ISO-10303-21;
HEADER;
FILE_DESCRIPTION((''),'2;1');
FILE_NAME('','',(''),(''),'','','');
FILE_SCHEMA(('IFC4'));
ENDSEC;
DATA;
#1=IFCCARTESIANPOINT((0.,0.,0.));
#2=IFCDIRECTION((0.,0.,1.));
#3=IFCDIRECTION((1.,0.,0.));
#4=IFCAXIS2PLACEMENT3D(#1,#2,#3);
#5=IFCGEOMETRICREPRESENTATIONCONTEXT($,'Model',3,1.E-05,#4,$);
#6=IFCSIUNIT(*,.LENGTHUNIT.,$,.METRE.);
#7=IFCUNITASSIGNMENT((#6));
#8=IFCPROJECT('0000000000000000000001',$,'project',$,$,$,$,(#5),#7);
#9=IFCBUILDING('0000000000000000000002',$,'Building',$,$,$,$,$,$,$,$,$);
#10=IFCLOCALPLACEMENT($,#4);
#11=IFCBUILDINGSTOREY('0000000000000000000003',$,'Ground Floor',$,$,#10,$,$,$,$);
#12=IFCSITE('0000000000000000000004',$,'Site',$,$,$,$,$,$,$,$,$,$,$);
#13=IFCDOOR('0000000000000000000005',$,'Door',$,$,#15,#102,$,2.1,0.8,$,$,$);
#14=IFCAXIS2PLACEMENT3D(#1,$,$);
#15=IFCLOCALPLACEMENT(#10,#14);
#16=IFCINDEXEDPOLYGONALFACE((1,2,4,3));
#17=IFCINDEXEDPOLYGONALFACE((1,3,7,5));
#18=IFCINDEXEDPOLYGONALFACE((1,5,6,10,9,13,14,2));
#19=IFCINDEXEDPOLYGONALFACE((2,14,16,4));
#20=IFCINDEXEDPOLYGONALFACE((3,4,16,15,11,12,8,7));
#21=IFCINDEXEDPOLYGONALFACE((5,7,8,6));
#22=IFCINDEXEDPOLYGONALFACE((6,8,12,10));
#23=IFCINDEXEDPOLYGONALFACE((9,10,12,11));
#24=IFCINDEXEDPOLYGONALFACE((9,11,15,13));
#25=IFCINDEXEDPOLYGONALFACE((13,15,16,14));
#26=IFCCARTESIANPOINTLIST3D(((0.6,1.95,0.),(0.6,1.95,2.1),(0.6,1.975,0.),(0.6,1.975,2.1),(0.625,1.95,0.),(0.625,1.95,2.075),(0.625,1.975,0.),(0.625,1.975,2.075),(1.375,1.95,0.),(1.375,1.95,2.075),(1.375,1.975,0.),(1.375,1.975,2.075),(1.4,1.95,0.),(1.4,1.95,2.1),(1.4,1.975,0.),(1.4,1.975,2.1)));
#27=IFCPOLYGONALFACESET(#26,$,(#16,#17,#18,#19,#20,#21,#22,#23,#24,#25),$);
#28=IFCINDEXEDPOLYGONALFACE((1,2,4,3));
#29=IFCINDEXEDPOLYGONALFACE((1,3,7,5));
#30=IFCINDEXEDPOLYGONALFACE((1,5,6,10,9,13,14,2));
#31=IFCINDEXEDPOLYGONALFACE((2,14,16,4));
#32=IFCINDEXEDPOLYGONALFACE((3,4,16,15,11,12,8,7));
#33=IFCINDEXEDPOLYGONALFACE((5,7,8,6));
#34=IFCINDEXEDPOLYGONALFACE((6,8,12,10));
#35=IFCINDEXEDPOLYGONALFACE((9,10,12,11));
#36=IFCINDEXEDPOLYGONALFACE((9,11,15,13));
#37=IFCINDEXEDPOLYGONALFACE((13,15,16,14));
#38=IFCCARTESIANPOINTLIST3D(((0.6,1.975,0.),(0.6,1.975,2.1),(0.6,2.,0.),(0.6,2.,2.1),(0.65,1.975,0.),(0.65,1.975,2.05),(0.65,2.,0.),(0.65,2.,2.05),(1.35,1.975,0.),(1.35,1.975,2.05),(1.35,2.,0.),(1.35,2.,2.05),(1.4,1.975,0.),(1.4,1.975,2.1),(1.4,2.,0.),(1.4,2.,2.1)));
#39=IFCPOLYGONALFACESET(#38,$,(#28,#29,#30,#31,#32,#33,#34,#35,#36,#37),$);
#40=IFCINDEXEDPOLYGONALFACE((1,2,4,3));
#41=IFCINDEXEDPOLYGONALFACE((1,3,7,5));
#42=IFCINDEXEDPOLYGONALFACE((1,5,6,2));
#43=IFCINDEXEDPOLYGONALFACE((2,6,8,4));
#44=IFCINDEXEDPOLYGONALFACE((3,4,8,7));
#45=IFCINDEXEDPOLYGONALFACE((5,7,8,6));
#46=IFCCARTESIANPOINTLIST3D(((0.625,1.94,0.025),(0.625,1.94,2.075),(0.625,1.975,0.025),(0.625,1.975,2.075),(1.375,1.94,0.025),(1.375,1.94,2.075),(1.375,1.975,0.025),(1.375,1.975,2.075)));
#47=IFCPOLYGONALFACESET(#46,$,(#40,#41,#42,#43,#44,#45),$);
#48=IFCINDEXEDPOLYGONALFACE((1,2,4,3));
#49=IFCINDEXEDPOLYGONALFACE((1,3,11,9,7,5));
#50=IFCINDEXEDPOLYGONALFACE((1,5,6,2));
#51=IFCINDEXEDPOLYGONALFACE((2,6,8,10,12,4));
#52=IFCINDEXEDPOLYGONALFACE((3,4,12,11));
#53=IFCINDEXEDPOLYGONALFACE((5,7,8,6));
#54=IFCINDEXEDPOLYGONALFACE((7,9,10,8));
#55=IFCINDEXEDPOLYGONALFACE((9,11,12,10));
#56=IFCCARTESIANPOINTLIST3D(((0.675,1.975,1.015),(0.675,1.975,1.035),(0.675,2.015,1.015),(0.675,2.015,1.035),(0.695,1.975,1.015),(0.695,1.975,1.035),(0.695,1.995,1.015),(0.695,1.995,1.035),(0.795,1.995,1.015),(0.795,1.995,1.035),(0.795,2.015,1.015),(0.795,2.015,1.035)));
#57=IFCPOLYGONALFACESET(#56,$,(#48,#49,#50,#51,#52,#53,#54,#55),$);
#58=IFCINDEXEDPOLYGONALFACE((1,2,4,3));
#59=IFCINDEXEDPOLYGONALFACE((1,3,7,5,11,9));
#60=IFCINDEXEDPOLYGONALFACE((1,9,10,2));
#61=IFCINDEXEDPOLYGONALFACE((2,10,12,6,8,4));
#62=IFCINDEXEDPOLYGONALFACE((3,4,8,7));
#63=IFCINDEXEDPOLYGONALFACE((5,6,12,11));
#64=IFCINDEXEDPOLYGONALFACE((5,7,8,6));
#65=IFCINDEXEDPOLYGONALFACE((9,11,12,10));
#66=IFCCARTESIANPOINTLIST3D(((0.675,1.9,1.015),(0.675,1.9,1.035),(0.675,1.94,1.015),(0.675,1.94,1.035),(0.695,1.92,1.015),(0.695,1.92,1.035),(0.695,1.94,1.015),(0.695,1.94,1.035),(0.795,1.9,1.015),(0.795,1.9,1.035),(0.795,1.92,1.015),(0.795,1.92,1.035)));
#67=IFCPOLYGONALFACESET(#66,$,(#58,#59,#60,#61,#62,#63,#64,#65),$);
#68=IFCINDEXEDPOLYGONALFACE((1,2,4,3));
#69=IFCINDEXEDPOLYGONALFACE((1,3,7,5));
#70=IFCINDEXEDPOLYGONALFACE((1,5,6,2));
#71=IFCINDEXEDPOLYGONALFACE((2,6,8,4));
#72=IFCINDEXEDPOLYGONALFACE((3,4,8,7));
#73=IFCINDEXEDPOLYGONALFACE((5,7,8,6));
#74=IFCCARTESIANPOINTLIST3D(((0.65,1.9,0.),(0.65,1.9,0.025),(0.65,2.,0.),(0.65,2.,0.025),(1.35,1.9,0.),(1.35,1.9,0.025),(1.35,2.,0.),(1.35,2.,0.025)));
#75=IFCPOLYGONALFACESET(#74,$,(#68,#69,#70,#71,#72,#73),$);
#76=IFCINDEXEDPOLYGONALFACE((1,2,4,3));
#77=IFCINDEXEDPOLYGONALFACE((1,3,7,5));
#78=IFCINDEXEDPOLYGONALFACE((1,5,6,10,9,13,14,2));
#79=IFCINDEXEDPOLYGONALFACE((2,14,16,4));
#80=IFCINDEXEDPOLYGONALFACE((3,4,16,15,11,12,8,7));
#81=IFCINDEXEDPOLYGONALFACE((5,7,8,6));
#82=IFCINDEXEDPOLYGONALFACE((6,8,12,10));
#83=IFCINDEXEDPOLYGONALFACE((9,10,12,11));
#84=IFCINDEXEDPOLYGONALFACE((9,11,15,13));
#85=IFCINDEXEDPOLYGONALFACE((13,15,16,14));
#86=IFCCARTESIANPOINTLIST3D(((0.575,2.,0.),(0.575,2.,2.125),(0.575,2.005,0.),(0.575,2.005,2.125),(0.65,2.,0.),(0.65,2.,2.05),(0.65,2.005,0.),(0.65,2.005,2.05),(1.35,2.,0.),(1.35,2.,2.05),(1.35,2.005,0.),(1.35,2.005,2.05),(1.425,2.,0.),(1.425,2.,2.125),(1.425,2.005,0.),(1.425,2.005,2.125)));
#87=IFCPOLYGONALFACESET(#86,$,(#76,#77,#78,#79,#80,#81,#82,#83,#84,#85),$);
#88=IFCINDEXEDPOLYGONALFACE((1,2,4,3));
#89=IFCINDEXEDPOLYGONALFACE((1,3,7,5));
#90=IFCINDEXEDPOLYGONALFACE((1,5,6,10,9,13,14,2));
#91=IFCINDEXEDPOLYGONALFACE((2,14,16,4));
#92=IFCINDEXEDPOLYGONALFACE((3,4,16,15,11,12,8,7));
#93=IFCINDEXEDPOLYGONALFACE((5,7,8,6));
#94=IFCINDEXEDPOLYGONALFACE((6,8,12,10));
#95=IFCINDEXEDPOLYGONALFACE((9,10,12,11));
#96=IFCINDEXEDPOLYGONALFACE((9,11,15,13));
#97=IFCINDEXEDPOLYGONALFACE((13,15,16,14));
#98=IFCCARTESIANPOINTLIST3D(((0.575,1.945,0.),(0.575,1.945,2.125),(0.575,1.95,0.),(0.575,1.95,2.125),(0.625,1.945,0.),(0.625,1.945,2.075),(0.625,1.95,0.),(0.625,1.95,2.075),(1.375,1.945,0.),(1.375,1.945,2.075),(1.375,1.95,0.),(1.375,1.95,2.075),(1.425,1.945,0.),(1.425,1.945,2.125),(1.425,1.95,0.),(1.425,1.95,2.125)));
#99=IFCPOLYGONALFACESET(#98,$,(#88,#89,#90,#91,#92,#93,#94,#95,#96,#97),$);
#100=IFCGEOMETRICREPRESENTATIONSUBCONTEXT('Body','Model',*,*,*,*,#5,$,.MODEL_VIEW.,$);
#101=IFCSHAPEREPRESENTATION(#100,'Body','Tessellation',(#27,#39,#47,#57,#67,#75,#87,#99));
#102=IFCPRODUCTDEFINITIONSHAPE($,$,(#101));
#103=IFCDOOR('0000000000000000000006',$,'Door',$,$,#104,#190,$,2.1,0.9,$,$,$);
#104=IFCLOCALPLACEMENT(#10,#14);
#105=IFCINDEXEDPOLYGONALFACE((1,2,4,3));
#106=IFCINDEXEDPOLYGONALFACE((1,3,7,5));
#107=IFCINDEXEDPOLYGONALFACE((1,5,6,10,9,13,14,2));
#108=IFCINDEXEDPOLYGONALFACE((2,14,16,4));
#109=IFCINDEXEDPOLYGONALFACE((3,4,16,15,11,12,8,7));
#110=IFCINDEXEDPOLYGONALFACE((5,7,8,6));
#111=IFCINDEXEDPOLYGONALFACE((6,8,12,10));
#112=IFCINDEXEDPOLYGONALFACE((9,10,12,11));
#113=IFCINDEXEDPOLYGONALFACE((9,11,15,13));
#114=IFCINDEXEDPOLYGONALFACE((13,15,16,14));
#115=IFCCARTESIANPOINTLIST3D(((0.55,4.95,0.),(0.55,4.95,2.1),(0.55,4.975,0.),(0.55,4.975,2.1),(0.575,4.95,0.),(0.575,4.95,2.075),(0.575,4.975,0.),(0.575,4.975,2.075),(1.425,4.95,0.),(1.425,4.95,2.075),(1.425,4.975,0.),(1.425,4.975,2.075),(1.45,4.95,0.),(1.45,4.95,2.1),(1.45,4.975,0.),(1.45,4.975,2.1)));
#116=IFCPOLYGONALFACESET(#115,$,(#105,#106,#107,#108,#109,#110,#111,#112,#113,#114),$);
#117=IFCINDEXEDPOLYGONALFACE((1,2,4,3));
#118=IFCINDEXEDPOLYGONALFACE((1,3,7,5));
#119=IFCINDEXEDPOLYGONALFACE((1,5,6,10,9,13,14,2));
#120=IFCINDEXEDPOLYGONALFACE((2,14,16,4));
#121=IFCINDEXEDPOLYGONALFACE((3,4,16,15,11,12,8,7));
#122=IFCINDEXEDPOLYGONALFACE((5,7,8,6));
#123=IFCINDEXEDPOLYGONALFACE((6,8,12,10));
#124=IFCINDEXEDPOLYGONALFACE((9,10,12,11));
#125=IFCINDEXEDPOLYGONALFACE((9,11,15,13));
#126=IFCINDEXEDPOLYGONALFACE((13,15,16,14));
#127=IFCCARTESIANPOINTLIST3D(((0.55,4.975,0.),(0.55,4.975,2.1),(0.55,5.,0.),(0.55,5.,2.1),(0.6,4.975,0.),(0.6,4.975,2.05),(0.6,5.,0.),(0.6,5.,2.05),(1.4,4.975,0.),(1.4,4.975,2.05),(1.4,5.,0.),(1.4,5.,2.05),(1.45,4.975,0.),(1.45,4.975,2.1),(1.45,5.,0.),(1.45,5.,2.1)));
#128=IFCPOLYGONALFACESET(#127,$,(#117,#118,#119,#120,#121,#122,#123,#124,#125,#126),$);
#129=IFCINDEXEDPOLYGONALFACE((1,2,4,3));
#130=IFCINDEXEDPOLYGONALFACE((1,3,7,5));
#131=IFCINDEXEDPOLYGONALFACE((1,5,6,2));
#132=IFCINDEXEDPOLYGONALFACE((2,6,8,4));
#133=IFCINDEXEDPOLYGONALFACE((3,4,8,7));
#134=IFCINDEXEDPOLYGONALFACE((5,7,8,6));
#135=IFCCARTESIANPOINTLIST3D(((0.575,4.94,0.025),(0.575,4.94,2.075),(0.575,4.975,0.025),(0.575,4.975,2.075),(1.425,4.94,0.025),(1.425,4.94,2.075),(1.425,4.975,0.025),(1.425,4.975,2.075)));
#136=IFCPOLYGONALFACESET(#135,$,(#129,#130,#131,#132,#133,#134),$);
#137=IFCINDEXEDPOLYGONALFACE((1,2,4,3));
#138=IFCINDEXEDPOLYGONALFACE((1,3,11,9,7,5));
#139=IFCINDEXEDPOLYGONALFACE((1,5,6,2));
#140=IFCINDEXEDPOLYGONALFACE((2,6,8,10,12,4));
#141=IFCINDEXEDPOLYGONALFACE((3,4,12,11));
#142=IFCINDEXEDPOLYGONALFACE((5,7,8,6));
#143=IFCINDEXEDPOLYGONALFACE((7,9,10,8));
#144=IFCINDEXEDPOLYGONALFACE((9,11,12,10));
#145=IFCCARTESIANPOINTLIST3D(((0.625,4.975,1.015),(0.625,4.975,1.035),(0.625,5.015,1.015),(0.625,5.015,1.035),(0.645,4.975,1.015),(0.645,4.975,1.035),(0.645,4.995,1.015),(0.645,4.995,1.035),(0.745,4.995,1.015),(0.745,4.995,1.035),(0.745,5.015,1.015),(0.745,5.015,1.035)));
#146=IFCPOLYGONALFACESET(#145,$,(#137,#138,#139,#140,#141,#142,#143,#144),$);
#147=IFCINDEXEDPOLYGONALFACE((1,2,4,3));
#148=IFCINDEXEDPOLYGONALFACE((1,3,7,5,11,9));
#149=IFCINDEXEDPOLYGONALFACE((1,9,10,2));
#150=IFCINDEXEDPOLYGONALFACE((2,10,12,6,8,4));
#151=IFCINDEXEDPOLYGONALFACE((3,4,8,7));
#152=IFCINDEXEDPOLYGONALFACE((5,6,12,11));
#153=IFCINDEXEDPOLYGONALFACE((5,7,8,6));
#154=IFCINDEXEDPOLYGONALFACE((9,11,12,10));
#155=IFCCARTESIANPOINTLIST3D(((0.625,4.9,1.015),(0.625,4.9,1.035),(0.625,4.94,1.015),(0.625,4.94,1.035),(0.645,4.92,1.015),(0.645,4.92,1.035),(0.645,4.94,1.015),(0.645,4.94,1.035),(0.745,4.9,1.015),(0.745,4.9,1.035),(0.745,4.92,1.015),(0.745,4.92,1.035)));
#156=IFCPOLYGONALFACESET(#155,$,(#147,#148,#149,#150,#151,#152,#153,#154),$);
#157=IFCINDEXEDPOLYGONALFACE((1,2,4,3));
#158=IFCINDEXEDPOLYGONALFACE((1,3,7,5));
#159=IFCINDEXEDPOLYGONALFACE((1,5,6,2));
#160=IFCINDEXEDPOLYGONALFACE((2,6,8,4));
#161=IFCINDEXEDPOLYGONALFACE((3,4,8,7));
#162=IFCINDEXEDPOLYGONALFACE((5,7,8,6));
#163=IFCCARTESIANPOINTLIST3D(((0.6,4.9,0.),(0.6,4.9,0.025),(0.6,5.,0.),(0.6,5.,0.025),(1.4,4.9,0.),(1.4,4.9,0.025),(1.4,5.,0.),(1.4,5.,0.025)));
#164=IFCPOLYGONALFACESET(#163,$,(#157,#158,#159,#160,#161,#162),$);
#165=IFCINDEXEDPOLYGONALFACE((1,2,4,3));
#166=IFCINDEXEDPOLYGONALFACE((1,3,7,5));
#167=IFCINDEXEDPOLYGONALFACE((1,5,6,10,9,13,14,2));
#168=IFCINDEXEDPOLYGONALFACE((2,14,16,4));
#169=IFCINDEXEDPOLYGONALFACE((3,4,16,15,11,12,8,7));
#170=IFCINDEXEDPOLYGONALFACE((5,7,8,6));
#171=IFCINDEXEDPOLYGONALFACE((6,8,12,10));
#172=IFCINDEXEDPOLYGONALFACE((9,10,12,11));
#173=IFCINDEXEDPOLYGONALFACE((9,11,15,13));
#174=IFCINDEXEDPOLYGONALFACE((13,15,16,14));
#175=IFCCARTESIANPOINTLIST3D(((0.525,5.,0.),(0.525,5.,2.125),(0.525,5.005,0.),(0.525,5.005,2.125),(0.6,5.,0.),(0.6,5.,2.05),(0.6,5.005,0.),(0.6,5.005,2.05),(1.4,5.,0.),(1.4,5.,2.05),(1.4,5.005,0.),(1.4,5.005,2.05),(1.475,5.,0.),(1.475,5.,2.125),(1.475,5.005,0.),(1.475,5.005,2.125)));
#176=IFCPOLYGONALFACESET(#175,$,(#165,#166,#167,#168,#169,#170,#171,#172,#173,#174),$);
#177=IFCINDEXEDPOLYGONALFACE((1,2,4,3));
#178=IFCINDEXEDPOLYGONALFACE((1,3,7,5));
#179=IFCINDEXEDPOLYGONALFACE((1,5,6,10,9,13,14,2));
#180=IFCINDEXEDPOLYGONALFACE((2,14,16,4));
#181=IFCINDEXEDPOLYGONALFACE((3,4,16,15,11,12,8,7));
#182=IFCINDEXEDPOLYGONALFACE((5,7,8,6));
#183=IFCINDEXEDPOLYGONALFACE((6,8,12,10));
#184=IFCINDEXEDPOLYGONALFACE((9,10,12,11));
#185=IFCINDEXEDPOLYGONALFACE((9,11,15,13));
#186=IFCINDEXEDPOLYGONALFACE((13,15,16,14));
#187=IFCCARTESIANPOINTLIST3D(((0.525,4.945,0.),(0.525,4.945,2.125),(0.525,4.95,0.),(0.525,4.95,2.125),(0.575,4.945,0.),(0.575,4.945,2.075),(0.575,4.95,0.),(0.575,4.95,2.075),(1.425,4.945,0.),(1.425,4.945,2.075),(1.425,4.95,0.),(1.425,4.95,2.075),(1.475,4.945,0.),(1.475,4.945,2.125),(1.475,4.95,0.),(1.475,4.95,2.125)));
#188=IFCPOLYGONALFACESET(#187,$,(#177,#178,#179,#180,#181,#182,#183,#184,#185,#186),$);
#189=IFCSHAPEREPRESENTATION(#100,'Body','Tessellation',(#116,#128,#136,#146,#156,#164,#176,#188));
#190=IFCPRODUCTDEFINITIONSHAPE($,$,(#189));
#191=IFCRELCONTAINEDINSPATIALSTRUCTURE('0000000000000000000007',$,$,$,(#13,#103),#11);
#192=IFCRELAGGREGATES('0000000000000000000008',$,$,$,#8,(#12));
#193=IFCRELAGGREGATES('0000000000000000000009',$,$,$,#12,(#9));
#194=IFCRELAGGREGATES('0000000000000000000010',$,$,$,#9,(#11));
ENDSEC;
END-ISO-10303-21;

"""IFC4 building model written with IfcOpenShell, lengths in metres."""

from ifc_helpers import new_model, si_unit, frame, origin_with_axes, place, context, subcontext, project, spatial, line, indexed_curve, outline, extrude, element, save


model = new_model("IFC4")

# Units and contexts
model_context = context("Model", 3, precision=1e-05, world=origin_with_axes())
body_context = subcontext(model_context, "Body", "Model", "MODEL_VIEW")
ifc_project = project(units=[si_unit("LENGTHUNIT", "METRE")], contexts=[model_context])

# Site, building, storey
site = spatial("IfcSite", under=ifc_project, Name="Site")
building = spatial("IfcBuilding", under=site, Name="Building")
storey_placement = place(None, origin_with_axes())
storey = spatial("IfcBuildingStorey", under=building, at=storey_placement, Name="Ground Floor")

# Doors
door_1_placement = place(storey_placement, frame((1.4, 2.0, 0.0), z_axis=(0.0, 0.0, 1.0), x_axis=(-1.0, 0.0, 0.0)))
element("IfcDoor", 1, at=door_1_placement, inside=storey, Name="Door", OverallHeight=2.1, OverallWidth=0.8, context=body_context, shape_type="SweptSolid", body=[
    extrude(outline(indexed_curve([(0.0, 0.0), (0.0, 2.1), (0.8, 2.1), (0.8, 0.0), (0.775, 0.0), (0.775, 2.075), (0.025, 2.075), (0.025, 0.0)], segments=[line(1, 2, 3, 4, 5, 6, 7, 8, 1)])), frame((0.0, 0.025, 0.0), z_axis=(0.0, -1.0, 0.0), x_axis=(1.0, 0.0, 0.0)), (0.0, 0.0, -1.0), 0.025),
    extrude(outline(indexed_curve([(0.0, 0.0), (0.0, 2.1), (0.8, 2.1), (0.8, 0.0), (0.75, 0.0), (0.75, 2.05), (0.05, 2.05), (0.05, 0.0)], segments=[line(1, 2, 3, 4, 5, 6, 7, 8, 1)])), frame((0.0, 0.0, 0.0), z_axis=(0.0, -1.0, 0.0), x_axis=(1.0, 0.0, 0.0)), (0.0, 0.0, -1.0), 0.025),
    extrude(outline(indexed_curve([(0.0, 0.0), (0.75, 0.0), (0.75, 0.035), (0.0, 0.035)], segments=[line(1, 2, 3, 4, 1)])), frame((0.025, 0.025, 0.025), z_axis=(0.0, 0.0, 1.0), x_axis=(1.0, 0.0, 0.0)), (0.0, 0.0, 1.0), 2.05),
    extrude(outline(indexed_curve([(0.0, 0.0), (0.0, -0.04), (-0.12, -0.04), (-0.12, -0.02), (-0.02, -0.02), (-0.02, 0.0)], segments=[line(1, 2, 3, 4, 5, 6, 1)])), frame((0.725, 0.025, 1.015), z_axis=(0.0, 0.0, 1.0), x_axis=(1.0, 0.0, 0.0)), (0.0, 0.0, 1.0), 0.02),
    extrude(outline(indexed_curve([(0.0, 0.0), (0.0, 0.04), (-0.12, 0.04), (-0.12, 0.02), (-0.02, 0.02), (-0.02, 0.0)], segments=[line(1, 2, 3, 4, 5, 6, 1)])), frame((0.725, 0.06, 1.015), z_axis=(0.0, 0.0, 1.0), x_axis=(1.0, 0.0, 0.0)), (0.0, 0.0, 1.0), 0.02),
    extrude(outline(indexed_curve([(0.0, 0.0), (0.7, 0.0), (0.7, 0.1), (0.0, 0.1)], segments=[line(1, 2, 3, 4, 1)])), frame((0.05, 0.0, 0.0), z_axis=(0.0, 0.0, 1.0), x_axis=(1.0, 0.0, 0.0)), (0.0, 0.0, 1.0), 0.025),
    extrude(outline(indexed_curve([(0.0, 0.0), (0.0, 2.125), (0.85, 2.125), (0.85, 0.0), (0.775, 0.0), (0.775, 2.05), (0.075, 2.05), (0.075, 0.0)], segments=[line(1, 2, 3, 4, 5, 6, 7, 8, 1)])), frame((-0.025, -0.005, 0.0), z_axis=(0.0, -1.0, 0.0), x_axis=(1.0, 0.0, 0.0)), (0.0, 0.0, -1.0), 0.005),
    extrude(outline(indexed_curve([(0.0, 0.0), (0.0, 2.125), (0.85, 2.125), (0.85, 0.0), (0.8, 0.0), (0.8, 2.075), (0.05, 2.075), (0.05, 0.0)], segments=[line(1, 2, 3, 4, 5, 6, 7, 8, 1)])), frame((-0.025, 0.05, 0.0), z_axis=(0.0, -1.0, 0.0), x_axis=(1.0, 0.0, 0.0)), (0.0, 0.0, -1.0), 0.005),
])
door_2_placement = place(storey_placement, frame((1.45, 5.0, 0.0), z_axis=(0.0, 0.0, 1.0), x_axis=(-1.0, 0.0, 0.0)))
element("IfcDoor", 2, at=door_2_placement, inside=storey, Name="Door", OverallHeight=2.1, OverallWidth=0.9, context=body_context, shape_type="SweptSolid", body=[
    extrude(outline(indexed_curve([(0.0, 0.0), (0.0, 2.1), (0.9, 2.1), (0.9, 0.0), (0.875, 0.0), (0.875, 2.075), (0.025, 2.075), (0.025, 0.0)], segments=[line(1, 2, 3, 4, 5, 6, 7, 8, 1)])), frame((0.0, 0.025, 0.0), z_axis=(0.0, -1.0, 0.0), x_axis=(1.0, 0.0, 0.0)), (0.0, 0.0, -1.0), 0.025),
    extrude(outline(indexed_curve([(0.0, 0.0), (0.0, 2.1), (0.9, 2.1), (0.9, 0.0), (0.85, 0.0), (0.85, 2.05), (0.05, 2.05), (0.05, 0.0)], segments=[line(1, 2, 3, 4, 5, 6, 7, 8, 1)])), frame((0.0, 0.0, 0.0), z_axis=(0.0, -1.0, 0.0), x_axis=(1.0, 0.0, 0.0)), (0.0, 0.0, -1.0), 0.025),
    extrude(outline(indexed_curve([(0.0, 0.0), (0.85, 0.0), (0.85, 0.035), (0.0, 0.035)], segments=[line(1, 2, 3, 4, 1)])), frame((0.025, 0.025, 0.025), z_axis=(0.0, 0.0, 1.0), x_axis=(1.0, 0.0, 0.0)), (0.0, 0.0, 1.0), 2.05),
    extrude(outline(indexed_curve([(0.0, 0.0), (0.0, -0.04), (-0.12, -0.04), (-0.12, -0.02), (-0.02, -0.02), (-0.02, 0.0)], segments=[line(1, 2, 3, 4, 5, 6, 1)])), frame((0.825, 0.025, 1.015), z_axis=(0.0, 0.0, 1.0), x_axis=(1.0, 0.0, 0.0)), (0.0, 0.0, 1.0), 0.02),
    extrude(outline(indexed_curve([(0.0, 0.0), (0.0, 0.04), (-0.12, 0.04), (-0.12, 0.02), (-0.02, 0.02), (-0.02, 0.0)], segments=[line(1, 2, 3, 4, 5, 6, 1)])), frame((0.825, 0.06, 1.015), z_axis=(0.0, 0.0, 1.0), x_axis=(1.0, 0.0, 0.0)), (0.0, 0.0, 1.0), 0.02),
    extrude(outline(indexed_curve([(0.0, 0.0), (0.8, 0.0), (0.8, 0.1), (0.0, 0.1)], segments=[line(1, 2, 3, 4, 1)])), frame((0.05, 0.0, 0.0), z_axis=(0.0, 0.0, 1.0), x_axis=(1.0, 0.0, 0.0)), (0.0, 0.0, 1.0), 0.025),
    extrude(outline(indexed_curve([(0.0, 0.0), (0.0, 2.125), (0.95, 2.125), (0.95, 0.0), (0.875, 0.0), (0.875, 2.05), (0.075, 2.05), (0.075, 0.0)], segments=[line(1, 2, 3, 4, 5, 6, 7, 8, 1)])), frame((-0.025, -0.005, 0.0), z_axis=(0.0, -1.0, 0.0), x_axis=(1.0, 0.0, 0.0)), (0.0, 0.0, -1.0), 0.005),
    extrude(outline(indexed_curve([(0.0, 0.0), (0.0, 2.125), (0.95, 2.125), (0.95, 0.0), (0.9, 0.0), (0.9, 2.075), (0.05, 2.075), (0.05, 0.0)], segments=[line(1, 2, 3, 4, 5, 6, 7, 8, 1)])), frame((-0.025, 0.05, 0.0), z_axis=(0.0, -1.0, 0.0), x_axis=(1.0, 0.0, 0.0)), (0.0, 0.0, -1.0), 0.005),
])

save(model, "model.ifc")
